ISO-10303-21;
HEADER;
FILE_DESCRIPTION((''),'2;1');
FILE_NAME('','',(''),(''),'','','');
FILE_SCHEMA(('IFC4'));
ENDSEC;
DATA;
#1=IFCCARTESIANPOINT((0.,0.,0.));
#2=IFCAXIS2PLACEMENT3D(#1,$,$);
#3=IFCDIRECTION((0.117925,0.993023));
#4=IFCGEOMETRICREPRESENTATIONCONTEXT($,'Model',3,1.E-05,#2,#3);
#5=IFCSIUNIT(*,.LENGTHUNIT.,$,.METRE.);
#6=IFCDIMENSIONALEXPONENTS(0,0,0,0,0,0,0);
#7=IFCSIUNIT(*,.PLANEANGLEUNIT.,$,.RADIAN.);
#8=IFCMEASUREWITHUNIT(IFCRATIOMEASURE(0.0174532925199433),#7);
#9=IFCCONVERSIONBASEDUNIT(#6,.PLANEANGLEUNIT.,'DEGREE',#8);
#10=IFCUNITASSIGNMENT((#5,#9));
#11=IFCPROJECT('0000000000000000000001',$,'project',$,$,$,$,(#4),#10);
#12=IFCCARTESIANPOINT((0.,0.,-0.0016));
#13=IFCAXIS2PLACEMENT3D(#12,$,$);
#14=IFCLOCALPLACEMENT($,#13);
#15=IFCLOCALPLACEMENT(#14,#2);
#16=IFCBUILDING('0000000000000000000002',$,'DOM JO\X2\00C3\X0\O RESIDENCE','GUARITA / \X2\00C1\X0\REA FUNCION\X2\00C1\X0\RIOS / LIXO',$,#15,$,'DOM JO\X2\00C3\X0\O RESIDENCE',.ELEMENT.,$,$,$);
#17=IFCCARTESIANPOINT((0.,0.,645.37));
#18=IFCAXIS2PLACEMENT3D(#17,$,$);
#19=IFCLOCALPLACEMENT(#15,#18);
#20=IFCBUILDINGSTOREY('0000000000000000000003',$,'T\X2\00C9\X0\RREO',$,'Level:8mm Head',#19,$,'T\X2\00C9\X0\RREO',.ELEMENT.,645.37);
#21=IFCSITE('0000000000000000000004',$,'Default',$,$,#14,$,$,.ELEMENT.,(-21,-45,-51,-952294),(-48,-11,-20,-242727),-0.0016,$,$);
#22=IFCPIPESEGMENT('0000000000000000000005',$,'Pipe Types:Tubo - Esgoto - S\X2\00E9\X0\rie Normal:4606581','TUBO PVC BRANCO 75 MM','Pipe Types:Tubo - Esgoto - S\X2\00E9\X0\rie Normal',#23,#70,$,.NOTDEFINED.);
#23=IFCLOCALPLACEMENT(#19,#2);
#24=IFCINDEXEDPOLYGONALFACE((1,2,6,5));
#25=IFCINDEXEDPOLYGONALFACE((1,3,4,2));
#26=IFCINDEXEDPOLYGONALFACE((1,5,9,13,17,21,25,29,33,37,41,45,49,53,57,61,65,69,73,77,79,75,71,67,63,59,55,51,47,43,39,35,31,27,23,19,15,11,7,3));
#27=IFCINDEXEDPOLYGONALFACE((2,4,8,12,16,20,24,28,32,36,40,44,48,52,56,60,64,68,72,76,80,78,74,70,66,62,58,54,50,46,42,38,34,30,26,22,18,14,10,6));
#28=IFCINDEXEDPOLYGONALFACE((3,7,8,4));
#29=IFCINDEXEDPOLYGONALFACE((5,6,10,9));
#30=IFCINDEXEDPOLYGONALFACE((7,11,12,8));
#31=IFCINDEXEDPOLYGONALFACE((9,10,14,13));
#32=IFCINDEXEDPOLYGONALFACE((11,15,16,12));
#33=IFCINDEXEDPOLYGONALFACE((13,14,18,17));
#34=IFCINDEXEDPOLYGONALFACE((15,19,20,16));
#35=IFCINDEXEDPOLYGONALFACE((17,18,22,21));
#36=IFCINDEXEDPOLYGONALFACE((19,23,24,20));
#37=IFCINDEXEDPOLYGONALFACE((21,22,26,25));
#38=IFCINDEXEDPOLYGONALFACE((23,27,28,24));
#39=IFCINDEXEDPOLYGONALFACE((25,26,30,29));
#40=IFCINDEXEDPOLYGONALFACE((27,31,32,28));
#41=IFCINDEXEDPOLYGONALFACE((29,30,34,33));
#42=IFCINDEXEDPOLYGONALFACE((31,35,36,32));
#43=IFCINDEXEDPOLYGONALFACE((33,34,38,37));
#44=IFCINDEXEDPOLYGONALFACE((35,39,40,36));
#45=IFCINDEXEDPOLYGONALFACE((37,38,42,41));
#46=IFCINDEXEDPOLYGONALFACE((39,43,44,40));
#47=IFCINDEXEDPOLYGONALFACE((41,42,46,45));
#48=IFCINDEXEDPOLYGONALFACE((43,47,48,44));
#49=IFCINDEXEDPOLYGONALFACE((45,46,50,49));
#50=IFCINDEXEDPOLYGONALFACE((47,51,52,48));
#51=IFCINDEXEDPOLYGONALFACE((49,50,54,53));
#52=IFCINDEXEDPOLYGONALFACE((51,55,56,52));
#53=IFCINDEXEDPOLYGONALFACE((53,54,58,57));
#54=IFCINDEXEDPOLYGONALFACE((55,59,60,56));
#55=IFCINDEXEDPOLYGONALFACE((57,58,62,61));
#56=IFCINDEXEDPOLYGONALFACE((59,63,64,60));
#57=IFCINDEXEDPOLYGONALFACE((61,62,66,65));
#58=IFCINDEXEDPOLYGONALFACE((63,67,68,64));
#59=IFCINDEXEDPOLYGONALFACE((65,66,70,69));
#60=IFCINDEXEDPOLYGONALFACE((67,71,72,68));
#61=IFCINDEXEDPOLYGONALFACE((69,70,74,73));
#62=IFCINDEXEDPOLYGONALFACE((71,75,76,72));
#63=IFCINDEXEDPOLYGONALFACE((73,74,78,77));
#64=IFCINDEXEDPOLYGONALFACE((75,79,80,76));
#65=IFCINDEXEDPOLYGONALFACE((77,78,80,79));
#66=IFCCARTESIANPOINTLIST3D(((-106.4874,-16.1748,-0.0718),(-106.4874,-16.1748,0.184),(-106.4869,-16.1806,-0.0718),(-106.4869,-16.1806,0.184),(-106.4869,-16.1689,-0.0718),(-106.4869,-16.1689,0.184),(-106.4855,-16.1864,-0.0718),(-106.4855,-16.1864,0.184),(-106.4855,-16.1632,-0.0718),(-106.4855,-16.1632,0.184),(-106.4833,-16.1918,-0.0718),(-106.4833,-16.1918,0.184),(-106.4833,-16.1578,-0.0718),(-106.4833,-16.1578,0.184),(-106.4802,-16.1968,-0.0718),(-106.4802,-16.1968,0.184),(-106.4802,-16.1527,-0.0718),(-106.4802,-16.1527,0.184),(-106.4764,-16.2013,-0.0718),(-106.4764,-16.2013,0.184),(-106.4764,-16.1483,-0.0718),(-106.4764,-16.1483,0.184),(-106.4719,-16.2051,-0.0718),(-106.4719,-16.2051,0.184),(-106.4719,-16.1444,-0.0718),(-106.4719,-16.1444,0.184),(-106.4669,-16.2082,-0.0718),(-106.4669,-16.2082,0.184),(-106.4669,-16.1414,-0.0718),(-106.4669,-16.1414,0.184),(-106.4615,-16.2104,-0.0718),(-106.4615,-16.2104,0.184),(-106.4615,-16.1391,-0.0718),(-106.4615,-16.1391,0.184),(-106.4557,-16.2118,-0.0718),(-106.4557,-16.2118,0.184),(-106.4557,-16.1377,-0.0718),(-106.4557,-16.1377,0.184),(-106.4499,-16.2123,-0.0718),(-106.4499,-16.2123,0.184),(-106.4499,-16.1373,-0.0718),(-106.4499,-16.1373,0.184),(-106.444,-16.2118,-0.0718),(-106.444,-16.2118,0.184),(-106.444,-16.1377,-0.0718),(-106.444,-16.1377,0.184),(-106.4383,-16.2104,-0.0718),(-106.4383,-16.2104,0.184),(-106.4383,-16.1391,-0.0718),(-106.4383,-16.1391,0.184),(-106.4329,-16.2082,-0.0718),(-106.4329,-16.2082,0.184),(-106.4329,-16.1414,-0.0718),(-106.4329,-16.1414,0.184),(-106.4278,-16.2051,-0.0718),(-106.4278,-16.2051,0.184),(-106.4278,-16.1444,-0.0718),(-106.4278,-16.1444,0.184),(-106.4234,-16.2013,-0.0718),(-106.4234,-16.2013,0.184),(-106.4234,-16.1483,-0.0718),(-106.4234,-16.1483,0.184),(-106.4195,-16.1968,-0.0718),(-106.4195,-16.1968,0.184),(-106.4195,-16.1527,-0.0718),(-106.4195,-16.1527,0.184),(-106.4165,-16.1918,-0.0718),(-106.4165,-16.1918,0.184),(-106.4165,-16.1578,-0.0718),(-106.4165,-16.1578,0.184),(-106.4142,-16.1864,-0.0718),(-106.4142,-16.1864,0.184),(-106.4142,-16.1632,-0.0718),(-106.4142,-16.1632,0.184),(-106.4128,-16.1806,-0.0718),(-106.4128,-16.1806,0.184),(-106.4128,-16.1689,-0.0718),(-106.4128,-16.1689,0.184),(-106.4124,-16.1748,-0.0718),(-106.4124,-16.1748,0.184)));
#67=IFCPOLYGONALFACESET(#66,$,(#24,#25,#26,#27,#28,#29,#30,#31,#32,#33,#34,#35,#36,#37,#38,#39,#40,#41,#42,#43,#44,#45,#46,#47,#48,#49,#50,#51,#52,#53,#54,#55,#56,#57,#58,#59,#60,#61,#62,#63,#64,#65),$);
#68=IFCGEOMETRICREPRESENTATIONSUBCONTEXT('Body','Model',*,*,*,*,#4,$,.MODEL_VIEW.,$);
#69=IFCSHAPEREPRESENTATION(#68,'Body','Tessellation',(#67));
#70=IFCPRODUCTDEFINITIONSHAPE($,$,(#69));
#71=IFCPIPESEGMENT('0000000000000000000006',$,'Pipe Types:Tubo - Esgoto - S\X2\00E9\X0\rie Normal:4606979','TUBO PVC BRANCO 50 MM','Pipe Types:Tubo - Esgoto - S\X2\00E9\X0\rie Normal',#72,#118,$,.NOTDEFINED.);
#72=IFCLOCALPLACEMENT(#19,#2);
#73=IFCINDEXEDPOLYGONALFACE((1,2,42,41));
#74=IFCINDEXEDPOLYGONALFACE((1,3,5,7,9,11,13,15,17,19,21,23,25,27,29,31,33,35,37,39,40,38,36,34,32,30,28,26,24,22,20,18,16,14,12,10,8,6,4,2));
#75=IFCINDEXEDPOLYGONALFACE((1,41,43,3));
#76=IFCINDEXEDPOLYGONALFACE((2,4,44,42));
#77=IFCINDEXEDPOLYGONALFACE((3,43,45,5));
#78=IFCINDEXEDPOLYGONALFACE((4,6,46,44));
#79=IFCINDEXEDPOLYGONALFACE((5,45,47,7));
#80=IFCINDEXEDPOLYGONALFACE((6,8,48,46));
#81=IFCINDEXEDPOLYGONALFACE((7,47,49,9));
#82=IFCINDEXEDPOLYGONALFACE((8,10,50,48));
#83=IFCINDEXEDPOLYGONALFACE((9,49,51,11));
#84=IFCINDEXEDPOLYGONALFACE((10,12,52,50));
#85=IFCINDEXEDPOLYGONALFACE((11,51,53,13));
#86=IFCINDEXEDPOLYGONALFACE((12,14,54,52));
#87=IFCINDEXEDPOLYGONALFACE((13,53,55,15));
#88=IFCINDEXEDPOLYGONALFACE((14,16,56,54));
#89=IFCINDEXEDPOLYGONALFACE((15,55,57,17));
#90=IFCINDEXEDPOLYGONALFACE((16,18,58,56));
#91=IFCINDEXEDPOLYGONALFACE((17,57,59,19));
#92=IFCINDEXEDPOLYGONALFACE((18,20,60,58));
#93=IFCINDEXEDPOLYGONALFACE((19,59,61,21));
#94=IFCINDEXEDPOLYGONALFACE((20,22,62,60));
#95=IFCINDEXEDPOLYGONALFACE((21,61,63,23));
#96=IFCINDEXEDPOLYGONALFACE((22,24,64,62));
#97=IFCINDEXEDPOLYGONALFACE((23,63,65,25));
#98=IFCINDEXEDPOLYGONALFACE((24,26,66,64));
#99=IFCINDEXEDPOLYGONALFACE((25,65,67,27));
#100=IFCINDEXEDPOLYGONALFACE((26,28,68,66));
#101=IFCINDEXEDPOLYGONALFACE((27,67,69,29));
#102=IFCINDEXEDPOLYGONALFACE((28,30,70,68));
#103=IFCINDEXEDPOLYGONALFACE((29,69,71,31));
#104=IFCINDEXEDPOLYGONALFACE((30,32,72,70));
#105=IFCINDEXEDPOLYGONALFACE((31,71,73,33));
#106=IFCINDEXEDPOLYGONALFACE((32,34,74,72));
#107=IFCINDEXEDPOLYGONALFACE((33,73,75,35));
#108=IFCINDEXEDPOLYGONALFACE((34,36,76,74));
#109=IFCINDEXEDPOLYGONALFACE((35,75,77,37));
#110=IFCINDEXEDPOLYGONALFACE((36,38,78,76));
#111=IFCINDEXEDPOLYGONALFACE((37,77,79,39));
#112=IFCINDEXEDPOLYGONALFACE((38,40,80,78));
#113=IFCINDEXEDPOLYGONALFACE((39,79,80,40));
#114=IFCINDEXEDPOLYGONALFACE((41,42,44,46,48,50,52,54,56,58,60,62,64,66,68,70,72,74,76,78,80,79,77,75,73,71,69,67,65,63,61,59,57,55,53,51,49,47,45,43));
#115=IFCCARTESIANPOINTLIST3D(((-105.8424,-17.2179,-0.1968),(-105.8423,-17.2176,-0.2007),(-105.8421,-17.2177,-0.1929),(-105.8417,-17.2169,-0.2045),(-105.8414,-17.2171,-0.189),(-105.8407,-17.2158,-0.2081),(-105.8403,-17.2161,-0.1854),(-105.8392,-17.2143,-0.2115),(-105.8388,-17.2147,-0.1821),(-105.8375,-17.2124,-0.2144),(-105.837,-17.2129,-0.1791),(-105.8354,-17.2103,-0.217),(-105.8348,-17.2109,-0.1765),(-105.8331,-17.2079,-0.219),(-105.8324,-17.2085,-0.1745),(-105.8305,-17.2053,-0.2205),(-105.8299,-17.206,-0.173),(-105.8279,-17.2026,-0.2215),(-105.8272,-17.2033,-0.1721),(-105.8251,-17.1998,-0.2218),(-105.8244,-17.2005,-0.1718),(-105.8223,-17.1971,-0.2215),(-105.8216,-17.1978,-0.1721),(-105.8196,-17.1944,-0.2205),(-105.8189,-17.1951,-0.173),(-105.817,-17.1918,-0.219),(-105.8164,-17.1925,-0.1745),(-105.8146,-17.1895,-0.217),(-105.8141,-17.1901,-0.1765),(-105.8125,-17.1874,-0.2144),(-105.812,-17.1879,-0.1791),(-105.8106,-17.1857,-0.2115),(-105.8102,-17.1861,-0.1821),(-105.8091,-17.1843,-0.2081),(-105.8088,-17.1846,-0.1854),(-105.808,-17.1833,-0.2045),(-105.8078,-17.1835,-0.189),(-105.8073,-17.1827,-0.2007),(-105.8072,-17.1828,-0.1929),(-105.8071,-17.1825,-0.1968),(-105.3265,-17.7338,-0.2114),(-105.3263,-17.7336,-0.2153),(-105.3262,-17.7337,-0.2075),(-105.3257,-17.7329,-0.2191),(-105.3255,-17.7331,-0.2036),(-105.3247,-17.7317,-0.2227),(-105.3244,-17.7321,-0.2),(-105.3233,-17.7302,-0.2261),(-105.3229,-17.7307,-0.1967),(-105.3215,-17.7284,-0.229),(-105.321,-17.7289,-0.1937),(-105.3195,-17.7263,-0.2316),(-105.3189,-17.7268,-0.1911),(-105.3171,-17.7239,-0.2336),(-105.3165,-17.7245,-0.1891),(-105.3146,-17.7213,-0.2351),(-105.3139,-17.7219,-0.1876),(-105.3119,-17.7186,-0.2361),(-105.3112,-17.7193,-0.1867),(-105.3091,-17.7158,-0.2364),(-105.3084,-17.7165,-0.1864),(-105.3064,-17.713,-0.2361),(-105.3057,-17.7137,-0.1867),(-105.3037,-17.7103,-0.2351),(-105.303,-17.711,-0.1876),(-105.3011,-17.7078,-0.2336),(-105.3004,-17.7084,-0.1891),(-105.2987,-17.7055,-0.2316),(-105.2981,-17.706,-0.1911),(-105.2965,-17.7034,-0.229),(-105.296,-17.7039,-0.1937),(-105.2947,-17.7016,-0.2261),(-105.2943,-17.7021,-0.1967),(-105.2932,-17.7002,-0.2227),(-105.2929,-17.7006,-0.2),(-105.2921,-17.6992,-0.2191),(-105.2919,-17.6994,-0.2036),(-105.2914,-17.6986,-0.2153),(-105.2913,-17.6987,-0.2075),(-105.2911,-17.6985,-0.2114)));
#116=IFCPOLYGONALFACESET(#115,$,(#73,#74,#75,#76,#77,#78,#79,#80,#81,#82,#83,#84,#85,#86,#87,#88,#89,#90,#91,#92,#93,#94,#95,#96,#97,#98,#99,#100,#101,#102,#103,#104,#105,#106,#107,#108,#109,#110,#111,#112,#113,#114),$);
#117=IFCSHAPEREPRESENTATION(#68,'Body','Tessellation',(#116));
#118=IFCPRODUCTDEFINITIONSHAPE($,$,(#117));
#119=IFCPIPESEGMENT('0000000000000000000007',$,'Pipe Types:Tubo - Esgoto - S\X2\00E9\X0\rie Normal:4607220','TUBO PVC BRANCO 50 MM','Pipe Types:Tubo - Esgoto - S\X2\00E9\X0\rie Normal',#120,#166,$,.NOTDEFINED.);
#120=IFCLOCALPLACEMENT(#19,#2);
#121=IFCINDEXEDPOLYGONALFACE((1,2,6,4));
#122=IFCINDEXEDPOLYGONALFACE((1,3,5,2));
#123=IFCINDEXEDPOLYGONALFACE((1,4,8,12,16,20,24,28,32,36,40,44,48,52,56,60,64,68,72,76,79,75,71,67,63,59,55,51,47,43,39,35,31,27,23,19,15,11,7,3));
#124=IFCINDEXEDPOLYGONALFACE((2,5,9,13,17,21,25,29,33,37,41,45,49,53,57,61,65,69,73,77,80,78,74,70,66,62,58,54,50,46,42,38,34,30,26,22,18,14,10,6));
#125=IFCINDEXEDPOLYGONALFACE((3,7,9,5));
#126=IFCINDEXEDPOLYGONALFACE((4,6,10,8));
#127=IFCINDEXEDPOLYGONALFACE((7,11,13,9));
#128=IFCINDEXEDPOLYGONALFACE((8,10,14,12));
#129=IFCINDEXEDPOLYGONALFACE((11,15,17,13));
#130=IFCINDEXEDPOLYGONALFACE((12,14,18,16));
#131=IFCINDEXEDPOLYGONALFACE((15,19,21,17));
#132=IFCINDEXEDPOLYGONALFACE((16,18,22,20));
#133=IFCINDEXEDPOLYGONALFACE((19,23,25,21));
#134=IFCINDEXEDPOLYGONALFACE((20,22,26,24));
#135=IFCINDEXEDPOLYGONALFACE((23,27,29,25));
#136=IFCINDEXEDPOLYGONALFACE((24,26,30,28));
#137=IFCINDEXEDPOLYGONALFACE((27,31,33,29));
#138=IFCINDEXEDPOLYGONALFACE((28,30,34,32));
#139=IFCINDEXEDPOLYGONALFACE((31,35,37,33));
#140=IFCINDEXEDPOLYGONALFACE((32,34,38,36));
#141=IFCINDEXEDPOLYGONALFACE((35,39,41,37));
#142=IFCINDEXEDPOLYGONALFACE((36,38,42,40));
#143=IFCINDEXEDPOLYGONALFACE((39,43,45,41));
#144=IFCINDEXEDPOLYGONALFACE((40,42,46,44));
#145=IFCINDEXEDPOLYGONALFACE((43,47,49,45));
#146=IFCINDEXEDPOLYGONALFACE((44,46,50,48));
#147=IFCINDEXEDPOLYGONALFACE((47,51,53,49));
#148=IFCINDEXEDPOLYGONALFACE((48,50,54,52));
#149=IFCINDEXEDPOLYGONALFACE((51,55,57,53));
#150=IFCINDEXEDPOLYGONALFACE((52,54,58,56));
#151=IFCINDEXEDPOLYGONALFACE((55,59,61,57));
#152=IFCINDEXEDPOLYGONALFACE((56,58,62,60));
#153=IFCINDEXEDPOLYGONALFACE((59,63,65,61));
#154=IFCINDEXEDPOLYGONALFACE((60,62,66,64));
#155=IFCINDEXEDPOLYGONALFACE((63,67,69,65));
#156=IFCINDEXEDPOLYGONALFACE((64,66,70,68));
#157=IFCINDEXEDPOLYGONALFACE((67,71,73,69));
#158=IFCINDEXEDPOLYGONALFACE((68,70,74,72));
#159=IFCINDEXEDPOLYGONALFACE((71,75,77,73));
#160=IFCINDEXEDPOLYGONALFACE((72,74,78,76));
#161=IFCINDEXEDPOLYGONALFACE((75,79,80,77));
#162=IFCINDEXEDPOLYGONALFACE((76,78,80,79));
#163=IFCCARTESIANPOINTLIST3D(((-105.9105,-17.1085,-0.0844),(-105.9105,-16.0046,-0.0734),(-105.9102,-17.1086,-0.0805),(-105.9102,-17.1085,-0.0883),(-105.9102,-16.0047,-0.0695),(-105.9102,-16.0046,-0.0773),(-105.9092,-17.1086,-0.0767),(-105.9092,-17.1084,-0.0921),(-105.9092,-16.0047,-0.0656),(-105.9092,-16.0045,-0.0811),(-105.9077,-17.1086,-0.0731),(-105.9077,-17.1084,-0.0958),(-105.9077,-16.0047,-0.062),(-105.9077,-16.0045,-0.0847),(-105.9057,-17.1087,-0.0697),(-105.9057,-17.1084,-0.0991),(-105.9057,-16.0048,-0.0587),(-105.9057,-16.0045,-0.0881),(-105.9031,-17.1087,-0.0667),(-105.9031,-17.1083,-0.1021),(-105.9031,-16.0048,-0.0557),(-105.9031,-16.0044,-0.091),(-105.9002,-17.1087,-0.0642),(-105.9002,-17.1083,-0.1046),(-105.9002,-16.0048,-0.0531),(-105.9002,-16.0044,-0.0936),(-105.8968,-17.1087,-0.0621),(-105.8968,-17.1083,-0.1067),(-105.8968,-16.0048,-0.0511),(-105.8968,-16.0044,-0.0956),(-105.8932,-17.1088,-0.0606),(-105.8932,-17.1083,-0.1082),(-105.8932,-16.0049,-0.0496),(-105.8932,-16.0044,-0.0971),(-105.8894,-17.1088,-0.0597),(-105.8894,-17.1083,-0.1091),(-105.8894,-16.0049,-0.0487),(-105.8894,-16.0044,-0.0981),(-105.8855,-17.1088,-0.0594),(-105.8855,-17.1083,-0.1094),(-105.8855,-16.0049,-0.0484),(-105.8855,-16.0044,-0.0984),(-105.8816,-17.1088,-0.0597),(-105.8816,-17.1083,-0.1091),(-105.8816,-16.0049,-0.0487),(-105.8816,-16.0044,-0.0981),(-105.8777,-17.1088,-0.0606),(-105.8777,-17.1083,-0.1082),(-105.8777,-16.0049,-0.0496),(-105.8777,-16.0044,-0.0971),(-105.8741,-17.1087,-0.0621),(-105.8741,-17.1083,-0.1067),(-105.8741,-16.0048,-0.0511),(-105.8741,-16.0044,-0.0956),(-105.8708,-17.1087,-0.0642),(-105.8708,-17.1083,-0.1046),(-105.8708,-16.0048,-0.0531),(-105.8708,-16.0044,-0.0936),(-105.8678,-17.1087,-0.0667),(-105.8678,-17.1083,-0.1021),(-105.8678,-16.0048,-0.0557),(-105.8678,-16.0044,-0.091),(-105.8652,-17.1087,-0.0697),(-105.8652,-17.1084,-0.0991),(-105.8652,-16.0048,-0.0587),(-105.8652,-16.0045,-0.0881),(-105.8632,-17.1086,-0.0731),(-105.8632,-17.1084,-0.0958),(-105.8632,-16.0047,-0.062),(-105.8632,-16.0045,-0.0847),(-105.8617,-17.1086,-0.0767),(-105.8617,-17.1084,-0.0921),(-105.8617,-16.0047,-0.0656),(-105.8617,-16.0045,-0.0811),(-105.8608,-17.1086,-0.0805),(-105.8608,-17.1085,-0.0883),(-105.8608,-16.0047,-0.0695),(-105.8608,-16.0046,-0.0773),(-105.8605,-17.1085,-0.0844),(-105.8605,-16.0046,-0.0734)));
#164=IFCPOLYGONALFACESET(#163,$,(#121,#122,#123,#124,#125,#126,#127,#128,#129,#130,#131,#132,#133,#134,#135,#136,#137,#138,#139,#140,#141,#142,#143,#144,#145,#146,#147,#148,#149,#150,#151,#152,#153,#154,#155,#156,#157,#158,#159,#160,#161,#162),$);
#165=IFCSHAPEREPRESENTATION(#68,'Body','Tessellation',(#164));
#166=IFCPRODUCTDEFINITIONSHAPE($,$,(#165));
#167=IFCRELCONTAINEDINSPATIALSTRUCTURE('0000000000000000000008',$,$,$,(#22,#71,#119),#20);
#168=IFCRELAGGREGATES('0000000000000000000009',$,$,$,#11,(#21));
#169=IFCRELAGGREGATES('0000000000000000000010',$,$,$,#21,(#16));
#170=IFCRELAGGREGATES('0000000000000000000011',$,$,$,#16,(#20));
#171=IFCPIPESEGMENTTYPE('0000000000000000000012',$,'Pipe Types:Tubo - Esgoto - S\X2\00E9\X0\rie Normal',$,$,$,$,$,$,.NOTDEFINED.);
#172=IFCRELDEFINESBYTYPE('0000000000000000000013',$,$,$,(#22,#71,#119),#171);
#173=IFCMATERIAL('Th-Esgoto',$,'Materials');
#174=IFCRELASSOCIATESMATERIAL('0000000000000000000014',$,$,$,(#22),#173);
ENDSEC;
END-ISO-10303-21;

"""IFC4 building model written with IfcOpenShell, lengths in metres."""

from ifc_helpers import new_model, entity, si_unit, converted_unit, direction, frame, origin, place, context, subcontext, project, spatial, indexed_curve, outline, extrude, material, type_object, element, save


model = new_model("IFC4")

# Units and contexts
model_context = context("Model", 3, precision=1e-05, world=origin(), true_north=direction((0.117925, 0.993023)))
body_context = subcontext(model_context, "Body", "Model", "MODEL_VIEW")
ifc_project = project(units=[si_unit("LENGTHUNIT", "METRE"), converted_unit("PLANEANGLEUNIT", "DEGREE", entity("IfcRatioMeasure", 0.0174532925199433), si_unit("PLANEANGLEUNIT", "RADIAN"), dimensions=[0, 0, 0, 0, 0, 0, 0])], contexts=[model_context])

# Site, building, storey
site_placement = place(None, frame((0.0, 0.0, -0.0016)))
site = spatial("IfcSite", under=ifc_project, at=site_placement, Name="Default", CompositionType="ELEMENT", RefLatitude=(-21, -45, -51, -952294), RefLongitude=(-48, -11, -20, -242727), RefElevation=-0.0016)
building_placement = place(site_placement, origin())
building = spatial("IfcBuilding", under=site, at=building_placement, Name="DOM JOÃO RESIDENCE", Description="GUARITA / ÁREA FUNCIONÁRIOS / LIXO", LongName="DOM JOÃO RESIDENCE", CompositionType="ELEMENT")
storey_placement = place(building_placement, frame((0.0, 0.0, 645.37)))
storey = spatial("IfcBuildingStorey", under=building, at=storey_placement, Name="TÉRREO", ObjectType="Level:8mm Head", LongName="TÉRREO", CompositionType="ELEMENT", Elevation=645.37)

# Pipe segments
ifc_material = material(Name="Th-Esgoto", Category="Materials")
pipe_segment_type_1 = type_object("IfcPipeSegmentType", Name="Pipe Types:Tubo - Esgoto - Série Normal", PredefinedType="NOTDEFINED")
pipe_segment_1_placement = place(storey_placement, frame((-106.489, -16.2139, -0.0718)))
element("IfcPipeSegment", 1, at=pipe_segment_1_placement, inside=storey, type_object=pipe_segment_type_1, material=ifc_material, Name="Pipe Types:Tubo - Esgoto - Série Normal:4606581", Description="TUBO PVC BRANCO 75 MM", ObjectType="Pipe Types:Tubo - Esgoto - Série Normal", PredefinedType="NOTDEFINED", context=body_context, shape_type="SweptSolid", body=[
    extrude(outline(indexed_curve([(0.0375, 0.0), (0.037, 0.0059), (0.0357, 0.0116), (0.0334, 0.017), (0.0303, 0.022), (0.0265, 0.0265), (0.022, 0.0303), (0.017, 0.0334), (0.0116, 0.0357), (0.0059, 0.037), (0.0, 0.0375), (-0.0059, 0.037), (-0.0116, 0.0357), (-0.017, 0.0334), (-0.022, 0.0303), (-0.0265, 0.0265), (-0.0303, 0.022), (-0.0334, 0.017), (-0.0357, 0.0116), (-0.037, 0.0059), (-0.0375, 0.0), (-0.037, -0.0059), (-0.0357, -0.0116), (-0.0334, -0.017), (-0.0303, -0.022), (-0.0265, -0.0265), (-0.022, -0.0303), (-0.017, -0.0334), (-0.0116, -0.0357), (-0.0059, -0.037), (0.0, -0.0375), (0.0059, -0.037), (0.0116, -0.0357), (0.017, -0.0334), (0.022, -0.0303), (0.0265, -0.0265), (0.0303, -0.022), (0.0334, -0.017), (0.0357, -0.0116), (0.037, -0.0059), (0.0375, 0.0)], self_intersect=False)), frame((0.0391, 0.0391, 0.0)), (0.0, 0.0, 1.0), 0.2558),
])
pipe_segment_2_placement = place(storey_placement, frame((-105.844, -17.7354, -0.238)))
element("IfcPipeSegment", 2, at=pipe_segment_2_placement, inside=storey, type_object=pipe_segment_type_1, Name="Pipe Types:Tubo - Esgoto - Série Normal:4606979", Description="TUBO PVC BRANCO 50 MM", ObjectType="Pipe Types:Tubo - Esgoto - Série Normal", PredefinedType="NOTDEFINED", context=body_context, shape_type="SweptSolid", body=[
    extrude(outline(indexed_curve([(0.025, 0.0), (0.0247, 0.0039), (0.0238, 0.0077), (0.0223, 0.0113), (0.0202, 0.0147), (0.0177, 0.0177), (0.0147, 0.0202), (0.0113, 0.0223), (0.0077, 0.0238), (0.0039, 0.0247), (0.0, 0.025), (-0.0039, 0.0247), (-0.0077, 0.0238), (-0.0113, 0.0223), (-0.0147, 0.0202), (-0.0177, 0.0177), (-0.0202, 0.0147), (-0.0223, 0.0113), (-0.0238, 0.0077), (-0.0247, 0.0039), (-0.025, 0.0), (-0.0247, -0.0039), (-0.0238, -0.0077), (-0.0223, -0.0113), (-0.0202, -0.0147), (-0.0177, -0.0177), (-0.0147, -0.0202), (-0.0113, -0.0223), (-0.0077, -0.0238), (-0.0039, -0.0247), (0.0, -0.025), (0.0039, -0.0247), (0.0077, -0.0238), (0.0113, -0.0223), (0.0147, -0.0202), (0.0177, -0.0177), (0.0202, -0.0147), (0.0223, -0.0113), (0.0238, -0.0077), (0.0247, -0.0039), (0.025, 0.0)], self_intersect=False)), frame((0.5352, 0.0193, 0.0266), z_axis=(-0.706965, 0.706965, 0.019996), x_axis=(0.707107, 0.707107, 0.0)), (0.0, 0.0, 1.0), 0.7298),
])
pipe_segment_3_placement = place(storey_placement, frame((-105.9121, -17.1104, -0.111)))
element("IfcPipeSegment", 3, at=pipe_segment_3_placement, inside=storey, type_object=pipe_segment_type_1, Name="Pipe Types:Tubo - Esgoto - Série Normal:4607220", Description="TUBO PVC BRANCO 50 MM", ObjectType="Pipe Types:Tubo - Esgoto - Série Normal", PredefinedType="NOTDEFINED", context=body_context, shape_type="SweptSolid", body=[
    extrude(outline(indexed_curve([(0.025, 0.0), (0.0247, 0.0039), (0.0238, 0.0077), (0.0223, 0.0113), (0.0202, 0.0147), (0.0177, 0.0177), (0.0147, 0.0202), (0.0113, 0.0223), (0.0077, 0.0238), (0.0039, 0.0247), (0.0, 0.025), (-0.0039, 0.0247), (-0.0077, 0.0238), (-0.0113, 0.0223), (-0.0147, 0.0202), (-0.0177, 0.0177), (-0.0202, 0.0147), (-0.0223, 0.0113), (-0.0238, 0.0077), (-0.0247, 0.0039), (-0.025, 0.0), (-0.0247, -0.0039), (-0.0238, -0.0077), (-0.0223, -0.0113), (-0.0202, -0.0147), (-0.0177, -0.0177), (-0.0147, -0.0202), (-0.0113, -0.0223), (-0.0077, -0.0238), (-0.0039, -0.0247), (0.0, -0.025), (0.0039, -0.0247), (0.0077, -0.0238), (0.0113, -0.0223), (0.0147, -0.0202), (0.0177, -0.0177), (0.0202, -0.0147), (0.0223, -0.0113), (0.0238, -0.0077), (0.0247, -0.0039), (0.025, 0.0)], self_intersect=False)), frame((0.0266, 0.0018, 0.0266), z_axis=(0.0, 0.99995, 0.01), x_axis=(1.0, 0.0, 0.0)), (0.0, 0.0, 1.0), 1.104),
])

save(model, "model.ifc")
